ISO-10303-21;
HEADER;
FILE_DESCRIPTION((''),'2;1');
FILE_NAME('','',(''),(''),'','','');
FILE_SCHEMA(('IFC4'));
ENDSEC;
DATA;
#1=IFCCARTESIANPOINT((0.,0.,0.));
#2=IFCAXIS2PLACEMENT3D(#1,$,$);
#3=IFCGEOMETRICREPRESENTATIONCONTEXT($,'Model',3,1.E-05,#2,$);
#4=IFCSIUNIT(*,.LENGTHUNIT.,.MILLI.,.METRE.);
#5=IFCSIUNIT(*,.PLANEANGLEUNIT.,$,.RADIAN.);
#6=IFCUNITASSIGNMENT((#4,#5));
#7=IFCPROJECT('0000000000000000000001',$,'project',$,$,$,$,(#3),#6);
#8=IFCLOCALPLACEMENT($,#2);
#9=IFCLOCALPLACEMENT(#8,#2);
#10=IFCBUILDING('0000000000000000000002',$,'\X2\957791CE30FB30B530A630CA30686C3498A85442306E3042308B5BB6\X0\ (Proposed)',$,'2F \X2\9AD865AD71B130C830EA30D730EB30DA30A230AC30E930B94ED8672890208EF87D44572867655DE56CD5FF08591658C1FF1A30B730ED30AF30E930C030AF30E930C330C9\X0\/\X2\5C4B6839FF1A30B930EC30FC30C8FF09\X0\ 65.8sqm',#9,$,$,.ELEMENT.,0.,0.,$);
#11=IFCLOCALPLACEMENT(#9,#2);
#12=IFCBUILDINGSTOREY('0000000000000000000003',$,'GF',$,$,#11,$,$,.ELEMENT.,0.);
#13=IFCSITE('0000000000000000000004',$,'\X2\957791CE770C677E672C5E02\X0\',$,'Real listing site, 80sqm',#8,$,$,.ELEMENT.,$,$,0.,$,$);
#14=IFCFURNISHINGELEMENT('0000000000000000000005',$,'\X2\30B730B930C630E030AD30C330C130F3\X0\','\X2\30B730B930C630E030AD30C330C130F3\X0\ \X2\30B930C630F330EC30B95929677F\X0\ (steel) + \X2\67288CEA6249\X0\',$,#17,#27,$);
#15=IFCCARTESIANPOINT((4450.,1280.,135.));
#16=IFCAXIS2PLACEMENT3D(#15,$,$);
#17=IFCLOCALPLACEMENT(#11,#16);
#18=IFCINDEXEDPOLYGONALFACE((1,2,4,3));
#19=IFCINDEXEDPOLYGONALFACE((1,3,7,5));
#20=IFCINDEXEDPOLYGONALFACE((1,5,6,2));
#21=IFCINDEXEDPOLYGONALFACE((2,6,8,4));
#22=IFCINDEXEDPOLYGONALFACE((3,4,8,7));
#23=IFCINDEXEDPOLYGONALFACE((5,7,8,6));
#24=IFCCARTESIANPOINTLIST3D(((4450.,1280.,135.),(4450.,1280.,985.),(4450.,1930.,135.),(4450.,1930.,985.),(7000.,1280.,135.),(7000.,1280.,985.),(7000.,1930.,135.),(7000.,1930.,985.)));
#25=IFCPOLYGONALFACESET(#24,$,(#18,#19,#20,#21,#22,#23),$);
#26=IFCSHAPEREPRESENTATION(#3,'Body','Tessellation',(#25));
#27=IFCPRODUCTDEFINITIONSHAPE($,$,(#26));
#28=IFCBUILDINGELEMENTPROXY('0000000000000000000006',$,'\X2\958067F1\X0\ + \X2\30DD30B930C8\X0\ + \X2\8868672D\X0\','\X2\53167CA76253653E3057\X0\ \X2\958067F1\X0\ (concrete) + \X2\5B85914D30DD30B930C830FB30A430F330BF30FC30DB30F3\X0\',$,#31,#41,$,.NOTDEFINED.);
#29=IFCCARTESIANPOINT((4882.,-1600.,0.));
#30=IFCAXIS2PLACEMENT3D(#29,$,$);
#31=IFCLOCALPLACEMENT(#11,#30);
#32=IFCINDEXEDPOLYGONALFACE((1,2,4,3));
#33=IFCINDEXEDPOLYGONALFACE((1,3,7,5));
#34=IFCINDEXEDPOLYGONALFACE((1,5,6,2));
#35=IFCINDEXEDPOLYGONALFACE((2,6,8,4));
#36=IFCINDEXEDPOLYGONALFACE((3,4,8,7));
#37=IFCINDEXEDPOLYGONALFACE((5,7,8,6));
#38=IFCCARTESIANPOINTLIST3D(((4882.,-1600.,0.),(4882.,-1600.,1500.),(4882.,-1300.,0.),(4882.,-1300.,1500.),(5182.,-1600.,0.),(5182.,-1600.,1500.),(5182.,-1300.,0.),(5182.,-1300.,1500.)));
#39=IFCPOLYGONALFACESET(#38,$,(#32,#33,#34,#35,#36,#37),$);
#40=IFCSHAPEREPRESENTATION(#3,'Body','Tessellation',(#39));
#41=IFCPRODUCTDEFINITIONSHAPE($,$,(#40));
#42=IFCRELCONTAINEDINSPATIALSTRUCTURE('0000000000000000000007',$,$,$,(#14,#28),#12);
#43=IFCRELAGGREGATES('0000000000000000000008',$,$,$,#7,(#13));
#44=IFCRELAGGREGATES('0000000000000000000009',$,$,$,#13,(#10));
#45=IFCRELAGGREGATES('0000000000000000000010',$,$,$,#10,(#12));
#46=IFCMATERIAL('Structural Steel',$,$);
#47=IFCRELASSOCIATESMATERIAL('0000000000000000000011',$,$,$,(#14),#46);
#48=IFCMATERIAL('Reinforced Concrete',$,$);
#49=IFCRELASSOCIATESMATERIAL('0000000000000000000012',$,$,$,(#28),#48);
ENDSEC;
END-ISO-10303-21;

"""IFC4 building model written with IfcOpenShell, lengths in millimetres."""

from ifc_helpers import new_model, si_unit, frame, frame_2d, origin, place, context, project, spatial, rectangle, extrude, material, element, save


model = new_model("IFC4")

# Units and contexts
model_context = context("Model", 3, precision=1e-05, world=origin())
ifc_project = project(units=[si_unit("LENGTHUNIT", "METRE", prefix="MILLI"), si_unit("PLANEANGLEUNIT", "RADIAN")], contexts=[model_context])

# Site, building, storey
site_placement = place(None, origin())
site = spatial("IfcSite", under=ifc_project, at=site_placement, Name="長野県松本市", ObjectType="Real listing site, 80sqm", CompositionType="ELEMENT", RefElevation=0.0)
building_placement = place(site_placement, origin())
building = spatial("IfcBuilding", under=site, at=building_placement, Name="長野・サウナと水風呂のある家 (Proposed)", ObjectType="2F 高断熱トリプルペアガラス付木造軸組在来工法（外壁：シロクラダクラッド/屋根：スレート） 65.8sqm", CompositionType="ELEMENT", ElevationOfRefHeight=0.0, ElevationOfTerrain=0.0)
storey_placement = place(building_placement, origin())
storey = spatial("IfcBuildingStorey", under=building, at=storey_placement, Name="GF", CompositionType="ELEMENT", Elevation=0.0)

# Shared definitions
ifc_material_1 = material(Name="Reinforced Concrete")

# Shared definitions
ifc_material_2 = material(Name="Structural Steel")

# Furnishing element
furnishing_1_placement = place(storey_placement, frame((4450.0, 1280.0, 135.0)))
element("IfcFurnishingElement", 1, at=furnishing_1_placement, inside=storey, material=ifc_material_2, Name="システムキッチン", Description="システムキッチン ステンレス天板 (steel) + 木質扉", context=model_context, shape_type="SweptSolid", body=[
    extrude(rectangle(XDim=2550.0, YDim=650.0, at=frame_2d((1275.0, 325.0))), frame((4450.0, 1280.0, 135.0)), (0.0, 0.0, 1.0), 850.0),
])

# Building element proxy
proxy_placement = place(storey_placement, frame((4882.0, -1600.0, 0.0)))
element("IfcBuildingElementProxy", 2, at=proxy_placement, inside=storey, material=ifc_material_1, Name="門柱 + ポスト + 表札", Description="化粧打放し 門柱 (concrete) + 宅配ポスト・インターホン", PredefinedType="NOTDEFINED", context=model_context, shape_type="SweptSolid", body=[
    extrude(rectangle(XDim=300.0, YDim=300.0, at=frame_2d((150.0, 150.0))), frame((4882.0, -1600.0, 0.0)), (0.0, 0.0, 1.0), 1500.0),
])

save(model, "model.ifc")
